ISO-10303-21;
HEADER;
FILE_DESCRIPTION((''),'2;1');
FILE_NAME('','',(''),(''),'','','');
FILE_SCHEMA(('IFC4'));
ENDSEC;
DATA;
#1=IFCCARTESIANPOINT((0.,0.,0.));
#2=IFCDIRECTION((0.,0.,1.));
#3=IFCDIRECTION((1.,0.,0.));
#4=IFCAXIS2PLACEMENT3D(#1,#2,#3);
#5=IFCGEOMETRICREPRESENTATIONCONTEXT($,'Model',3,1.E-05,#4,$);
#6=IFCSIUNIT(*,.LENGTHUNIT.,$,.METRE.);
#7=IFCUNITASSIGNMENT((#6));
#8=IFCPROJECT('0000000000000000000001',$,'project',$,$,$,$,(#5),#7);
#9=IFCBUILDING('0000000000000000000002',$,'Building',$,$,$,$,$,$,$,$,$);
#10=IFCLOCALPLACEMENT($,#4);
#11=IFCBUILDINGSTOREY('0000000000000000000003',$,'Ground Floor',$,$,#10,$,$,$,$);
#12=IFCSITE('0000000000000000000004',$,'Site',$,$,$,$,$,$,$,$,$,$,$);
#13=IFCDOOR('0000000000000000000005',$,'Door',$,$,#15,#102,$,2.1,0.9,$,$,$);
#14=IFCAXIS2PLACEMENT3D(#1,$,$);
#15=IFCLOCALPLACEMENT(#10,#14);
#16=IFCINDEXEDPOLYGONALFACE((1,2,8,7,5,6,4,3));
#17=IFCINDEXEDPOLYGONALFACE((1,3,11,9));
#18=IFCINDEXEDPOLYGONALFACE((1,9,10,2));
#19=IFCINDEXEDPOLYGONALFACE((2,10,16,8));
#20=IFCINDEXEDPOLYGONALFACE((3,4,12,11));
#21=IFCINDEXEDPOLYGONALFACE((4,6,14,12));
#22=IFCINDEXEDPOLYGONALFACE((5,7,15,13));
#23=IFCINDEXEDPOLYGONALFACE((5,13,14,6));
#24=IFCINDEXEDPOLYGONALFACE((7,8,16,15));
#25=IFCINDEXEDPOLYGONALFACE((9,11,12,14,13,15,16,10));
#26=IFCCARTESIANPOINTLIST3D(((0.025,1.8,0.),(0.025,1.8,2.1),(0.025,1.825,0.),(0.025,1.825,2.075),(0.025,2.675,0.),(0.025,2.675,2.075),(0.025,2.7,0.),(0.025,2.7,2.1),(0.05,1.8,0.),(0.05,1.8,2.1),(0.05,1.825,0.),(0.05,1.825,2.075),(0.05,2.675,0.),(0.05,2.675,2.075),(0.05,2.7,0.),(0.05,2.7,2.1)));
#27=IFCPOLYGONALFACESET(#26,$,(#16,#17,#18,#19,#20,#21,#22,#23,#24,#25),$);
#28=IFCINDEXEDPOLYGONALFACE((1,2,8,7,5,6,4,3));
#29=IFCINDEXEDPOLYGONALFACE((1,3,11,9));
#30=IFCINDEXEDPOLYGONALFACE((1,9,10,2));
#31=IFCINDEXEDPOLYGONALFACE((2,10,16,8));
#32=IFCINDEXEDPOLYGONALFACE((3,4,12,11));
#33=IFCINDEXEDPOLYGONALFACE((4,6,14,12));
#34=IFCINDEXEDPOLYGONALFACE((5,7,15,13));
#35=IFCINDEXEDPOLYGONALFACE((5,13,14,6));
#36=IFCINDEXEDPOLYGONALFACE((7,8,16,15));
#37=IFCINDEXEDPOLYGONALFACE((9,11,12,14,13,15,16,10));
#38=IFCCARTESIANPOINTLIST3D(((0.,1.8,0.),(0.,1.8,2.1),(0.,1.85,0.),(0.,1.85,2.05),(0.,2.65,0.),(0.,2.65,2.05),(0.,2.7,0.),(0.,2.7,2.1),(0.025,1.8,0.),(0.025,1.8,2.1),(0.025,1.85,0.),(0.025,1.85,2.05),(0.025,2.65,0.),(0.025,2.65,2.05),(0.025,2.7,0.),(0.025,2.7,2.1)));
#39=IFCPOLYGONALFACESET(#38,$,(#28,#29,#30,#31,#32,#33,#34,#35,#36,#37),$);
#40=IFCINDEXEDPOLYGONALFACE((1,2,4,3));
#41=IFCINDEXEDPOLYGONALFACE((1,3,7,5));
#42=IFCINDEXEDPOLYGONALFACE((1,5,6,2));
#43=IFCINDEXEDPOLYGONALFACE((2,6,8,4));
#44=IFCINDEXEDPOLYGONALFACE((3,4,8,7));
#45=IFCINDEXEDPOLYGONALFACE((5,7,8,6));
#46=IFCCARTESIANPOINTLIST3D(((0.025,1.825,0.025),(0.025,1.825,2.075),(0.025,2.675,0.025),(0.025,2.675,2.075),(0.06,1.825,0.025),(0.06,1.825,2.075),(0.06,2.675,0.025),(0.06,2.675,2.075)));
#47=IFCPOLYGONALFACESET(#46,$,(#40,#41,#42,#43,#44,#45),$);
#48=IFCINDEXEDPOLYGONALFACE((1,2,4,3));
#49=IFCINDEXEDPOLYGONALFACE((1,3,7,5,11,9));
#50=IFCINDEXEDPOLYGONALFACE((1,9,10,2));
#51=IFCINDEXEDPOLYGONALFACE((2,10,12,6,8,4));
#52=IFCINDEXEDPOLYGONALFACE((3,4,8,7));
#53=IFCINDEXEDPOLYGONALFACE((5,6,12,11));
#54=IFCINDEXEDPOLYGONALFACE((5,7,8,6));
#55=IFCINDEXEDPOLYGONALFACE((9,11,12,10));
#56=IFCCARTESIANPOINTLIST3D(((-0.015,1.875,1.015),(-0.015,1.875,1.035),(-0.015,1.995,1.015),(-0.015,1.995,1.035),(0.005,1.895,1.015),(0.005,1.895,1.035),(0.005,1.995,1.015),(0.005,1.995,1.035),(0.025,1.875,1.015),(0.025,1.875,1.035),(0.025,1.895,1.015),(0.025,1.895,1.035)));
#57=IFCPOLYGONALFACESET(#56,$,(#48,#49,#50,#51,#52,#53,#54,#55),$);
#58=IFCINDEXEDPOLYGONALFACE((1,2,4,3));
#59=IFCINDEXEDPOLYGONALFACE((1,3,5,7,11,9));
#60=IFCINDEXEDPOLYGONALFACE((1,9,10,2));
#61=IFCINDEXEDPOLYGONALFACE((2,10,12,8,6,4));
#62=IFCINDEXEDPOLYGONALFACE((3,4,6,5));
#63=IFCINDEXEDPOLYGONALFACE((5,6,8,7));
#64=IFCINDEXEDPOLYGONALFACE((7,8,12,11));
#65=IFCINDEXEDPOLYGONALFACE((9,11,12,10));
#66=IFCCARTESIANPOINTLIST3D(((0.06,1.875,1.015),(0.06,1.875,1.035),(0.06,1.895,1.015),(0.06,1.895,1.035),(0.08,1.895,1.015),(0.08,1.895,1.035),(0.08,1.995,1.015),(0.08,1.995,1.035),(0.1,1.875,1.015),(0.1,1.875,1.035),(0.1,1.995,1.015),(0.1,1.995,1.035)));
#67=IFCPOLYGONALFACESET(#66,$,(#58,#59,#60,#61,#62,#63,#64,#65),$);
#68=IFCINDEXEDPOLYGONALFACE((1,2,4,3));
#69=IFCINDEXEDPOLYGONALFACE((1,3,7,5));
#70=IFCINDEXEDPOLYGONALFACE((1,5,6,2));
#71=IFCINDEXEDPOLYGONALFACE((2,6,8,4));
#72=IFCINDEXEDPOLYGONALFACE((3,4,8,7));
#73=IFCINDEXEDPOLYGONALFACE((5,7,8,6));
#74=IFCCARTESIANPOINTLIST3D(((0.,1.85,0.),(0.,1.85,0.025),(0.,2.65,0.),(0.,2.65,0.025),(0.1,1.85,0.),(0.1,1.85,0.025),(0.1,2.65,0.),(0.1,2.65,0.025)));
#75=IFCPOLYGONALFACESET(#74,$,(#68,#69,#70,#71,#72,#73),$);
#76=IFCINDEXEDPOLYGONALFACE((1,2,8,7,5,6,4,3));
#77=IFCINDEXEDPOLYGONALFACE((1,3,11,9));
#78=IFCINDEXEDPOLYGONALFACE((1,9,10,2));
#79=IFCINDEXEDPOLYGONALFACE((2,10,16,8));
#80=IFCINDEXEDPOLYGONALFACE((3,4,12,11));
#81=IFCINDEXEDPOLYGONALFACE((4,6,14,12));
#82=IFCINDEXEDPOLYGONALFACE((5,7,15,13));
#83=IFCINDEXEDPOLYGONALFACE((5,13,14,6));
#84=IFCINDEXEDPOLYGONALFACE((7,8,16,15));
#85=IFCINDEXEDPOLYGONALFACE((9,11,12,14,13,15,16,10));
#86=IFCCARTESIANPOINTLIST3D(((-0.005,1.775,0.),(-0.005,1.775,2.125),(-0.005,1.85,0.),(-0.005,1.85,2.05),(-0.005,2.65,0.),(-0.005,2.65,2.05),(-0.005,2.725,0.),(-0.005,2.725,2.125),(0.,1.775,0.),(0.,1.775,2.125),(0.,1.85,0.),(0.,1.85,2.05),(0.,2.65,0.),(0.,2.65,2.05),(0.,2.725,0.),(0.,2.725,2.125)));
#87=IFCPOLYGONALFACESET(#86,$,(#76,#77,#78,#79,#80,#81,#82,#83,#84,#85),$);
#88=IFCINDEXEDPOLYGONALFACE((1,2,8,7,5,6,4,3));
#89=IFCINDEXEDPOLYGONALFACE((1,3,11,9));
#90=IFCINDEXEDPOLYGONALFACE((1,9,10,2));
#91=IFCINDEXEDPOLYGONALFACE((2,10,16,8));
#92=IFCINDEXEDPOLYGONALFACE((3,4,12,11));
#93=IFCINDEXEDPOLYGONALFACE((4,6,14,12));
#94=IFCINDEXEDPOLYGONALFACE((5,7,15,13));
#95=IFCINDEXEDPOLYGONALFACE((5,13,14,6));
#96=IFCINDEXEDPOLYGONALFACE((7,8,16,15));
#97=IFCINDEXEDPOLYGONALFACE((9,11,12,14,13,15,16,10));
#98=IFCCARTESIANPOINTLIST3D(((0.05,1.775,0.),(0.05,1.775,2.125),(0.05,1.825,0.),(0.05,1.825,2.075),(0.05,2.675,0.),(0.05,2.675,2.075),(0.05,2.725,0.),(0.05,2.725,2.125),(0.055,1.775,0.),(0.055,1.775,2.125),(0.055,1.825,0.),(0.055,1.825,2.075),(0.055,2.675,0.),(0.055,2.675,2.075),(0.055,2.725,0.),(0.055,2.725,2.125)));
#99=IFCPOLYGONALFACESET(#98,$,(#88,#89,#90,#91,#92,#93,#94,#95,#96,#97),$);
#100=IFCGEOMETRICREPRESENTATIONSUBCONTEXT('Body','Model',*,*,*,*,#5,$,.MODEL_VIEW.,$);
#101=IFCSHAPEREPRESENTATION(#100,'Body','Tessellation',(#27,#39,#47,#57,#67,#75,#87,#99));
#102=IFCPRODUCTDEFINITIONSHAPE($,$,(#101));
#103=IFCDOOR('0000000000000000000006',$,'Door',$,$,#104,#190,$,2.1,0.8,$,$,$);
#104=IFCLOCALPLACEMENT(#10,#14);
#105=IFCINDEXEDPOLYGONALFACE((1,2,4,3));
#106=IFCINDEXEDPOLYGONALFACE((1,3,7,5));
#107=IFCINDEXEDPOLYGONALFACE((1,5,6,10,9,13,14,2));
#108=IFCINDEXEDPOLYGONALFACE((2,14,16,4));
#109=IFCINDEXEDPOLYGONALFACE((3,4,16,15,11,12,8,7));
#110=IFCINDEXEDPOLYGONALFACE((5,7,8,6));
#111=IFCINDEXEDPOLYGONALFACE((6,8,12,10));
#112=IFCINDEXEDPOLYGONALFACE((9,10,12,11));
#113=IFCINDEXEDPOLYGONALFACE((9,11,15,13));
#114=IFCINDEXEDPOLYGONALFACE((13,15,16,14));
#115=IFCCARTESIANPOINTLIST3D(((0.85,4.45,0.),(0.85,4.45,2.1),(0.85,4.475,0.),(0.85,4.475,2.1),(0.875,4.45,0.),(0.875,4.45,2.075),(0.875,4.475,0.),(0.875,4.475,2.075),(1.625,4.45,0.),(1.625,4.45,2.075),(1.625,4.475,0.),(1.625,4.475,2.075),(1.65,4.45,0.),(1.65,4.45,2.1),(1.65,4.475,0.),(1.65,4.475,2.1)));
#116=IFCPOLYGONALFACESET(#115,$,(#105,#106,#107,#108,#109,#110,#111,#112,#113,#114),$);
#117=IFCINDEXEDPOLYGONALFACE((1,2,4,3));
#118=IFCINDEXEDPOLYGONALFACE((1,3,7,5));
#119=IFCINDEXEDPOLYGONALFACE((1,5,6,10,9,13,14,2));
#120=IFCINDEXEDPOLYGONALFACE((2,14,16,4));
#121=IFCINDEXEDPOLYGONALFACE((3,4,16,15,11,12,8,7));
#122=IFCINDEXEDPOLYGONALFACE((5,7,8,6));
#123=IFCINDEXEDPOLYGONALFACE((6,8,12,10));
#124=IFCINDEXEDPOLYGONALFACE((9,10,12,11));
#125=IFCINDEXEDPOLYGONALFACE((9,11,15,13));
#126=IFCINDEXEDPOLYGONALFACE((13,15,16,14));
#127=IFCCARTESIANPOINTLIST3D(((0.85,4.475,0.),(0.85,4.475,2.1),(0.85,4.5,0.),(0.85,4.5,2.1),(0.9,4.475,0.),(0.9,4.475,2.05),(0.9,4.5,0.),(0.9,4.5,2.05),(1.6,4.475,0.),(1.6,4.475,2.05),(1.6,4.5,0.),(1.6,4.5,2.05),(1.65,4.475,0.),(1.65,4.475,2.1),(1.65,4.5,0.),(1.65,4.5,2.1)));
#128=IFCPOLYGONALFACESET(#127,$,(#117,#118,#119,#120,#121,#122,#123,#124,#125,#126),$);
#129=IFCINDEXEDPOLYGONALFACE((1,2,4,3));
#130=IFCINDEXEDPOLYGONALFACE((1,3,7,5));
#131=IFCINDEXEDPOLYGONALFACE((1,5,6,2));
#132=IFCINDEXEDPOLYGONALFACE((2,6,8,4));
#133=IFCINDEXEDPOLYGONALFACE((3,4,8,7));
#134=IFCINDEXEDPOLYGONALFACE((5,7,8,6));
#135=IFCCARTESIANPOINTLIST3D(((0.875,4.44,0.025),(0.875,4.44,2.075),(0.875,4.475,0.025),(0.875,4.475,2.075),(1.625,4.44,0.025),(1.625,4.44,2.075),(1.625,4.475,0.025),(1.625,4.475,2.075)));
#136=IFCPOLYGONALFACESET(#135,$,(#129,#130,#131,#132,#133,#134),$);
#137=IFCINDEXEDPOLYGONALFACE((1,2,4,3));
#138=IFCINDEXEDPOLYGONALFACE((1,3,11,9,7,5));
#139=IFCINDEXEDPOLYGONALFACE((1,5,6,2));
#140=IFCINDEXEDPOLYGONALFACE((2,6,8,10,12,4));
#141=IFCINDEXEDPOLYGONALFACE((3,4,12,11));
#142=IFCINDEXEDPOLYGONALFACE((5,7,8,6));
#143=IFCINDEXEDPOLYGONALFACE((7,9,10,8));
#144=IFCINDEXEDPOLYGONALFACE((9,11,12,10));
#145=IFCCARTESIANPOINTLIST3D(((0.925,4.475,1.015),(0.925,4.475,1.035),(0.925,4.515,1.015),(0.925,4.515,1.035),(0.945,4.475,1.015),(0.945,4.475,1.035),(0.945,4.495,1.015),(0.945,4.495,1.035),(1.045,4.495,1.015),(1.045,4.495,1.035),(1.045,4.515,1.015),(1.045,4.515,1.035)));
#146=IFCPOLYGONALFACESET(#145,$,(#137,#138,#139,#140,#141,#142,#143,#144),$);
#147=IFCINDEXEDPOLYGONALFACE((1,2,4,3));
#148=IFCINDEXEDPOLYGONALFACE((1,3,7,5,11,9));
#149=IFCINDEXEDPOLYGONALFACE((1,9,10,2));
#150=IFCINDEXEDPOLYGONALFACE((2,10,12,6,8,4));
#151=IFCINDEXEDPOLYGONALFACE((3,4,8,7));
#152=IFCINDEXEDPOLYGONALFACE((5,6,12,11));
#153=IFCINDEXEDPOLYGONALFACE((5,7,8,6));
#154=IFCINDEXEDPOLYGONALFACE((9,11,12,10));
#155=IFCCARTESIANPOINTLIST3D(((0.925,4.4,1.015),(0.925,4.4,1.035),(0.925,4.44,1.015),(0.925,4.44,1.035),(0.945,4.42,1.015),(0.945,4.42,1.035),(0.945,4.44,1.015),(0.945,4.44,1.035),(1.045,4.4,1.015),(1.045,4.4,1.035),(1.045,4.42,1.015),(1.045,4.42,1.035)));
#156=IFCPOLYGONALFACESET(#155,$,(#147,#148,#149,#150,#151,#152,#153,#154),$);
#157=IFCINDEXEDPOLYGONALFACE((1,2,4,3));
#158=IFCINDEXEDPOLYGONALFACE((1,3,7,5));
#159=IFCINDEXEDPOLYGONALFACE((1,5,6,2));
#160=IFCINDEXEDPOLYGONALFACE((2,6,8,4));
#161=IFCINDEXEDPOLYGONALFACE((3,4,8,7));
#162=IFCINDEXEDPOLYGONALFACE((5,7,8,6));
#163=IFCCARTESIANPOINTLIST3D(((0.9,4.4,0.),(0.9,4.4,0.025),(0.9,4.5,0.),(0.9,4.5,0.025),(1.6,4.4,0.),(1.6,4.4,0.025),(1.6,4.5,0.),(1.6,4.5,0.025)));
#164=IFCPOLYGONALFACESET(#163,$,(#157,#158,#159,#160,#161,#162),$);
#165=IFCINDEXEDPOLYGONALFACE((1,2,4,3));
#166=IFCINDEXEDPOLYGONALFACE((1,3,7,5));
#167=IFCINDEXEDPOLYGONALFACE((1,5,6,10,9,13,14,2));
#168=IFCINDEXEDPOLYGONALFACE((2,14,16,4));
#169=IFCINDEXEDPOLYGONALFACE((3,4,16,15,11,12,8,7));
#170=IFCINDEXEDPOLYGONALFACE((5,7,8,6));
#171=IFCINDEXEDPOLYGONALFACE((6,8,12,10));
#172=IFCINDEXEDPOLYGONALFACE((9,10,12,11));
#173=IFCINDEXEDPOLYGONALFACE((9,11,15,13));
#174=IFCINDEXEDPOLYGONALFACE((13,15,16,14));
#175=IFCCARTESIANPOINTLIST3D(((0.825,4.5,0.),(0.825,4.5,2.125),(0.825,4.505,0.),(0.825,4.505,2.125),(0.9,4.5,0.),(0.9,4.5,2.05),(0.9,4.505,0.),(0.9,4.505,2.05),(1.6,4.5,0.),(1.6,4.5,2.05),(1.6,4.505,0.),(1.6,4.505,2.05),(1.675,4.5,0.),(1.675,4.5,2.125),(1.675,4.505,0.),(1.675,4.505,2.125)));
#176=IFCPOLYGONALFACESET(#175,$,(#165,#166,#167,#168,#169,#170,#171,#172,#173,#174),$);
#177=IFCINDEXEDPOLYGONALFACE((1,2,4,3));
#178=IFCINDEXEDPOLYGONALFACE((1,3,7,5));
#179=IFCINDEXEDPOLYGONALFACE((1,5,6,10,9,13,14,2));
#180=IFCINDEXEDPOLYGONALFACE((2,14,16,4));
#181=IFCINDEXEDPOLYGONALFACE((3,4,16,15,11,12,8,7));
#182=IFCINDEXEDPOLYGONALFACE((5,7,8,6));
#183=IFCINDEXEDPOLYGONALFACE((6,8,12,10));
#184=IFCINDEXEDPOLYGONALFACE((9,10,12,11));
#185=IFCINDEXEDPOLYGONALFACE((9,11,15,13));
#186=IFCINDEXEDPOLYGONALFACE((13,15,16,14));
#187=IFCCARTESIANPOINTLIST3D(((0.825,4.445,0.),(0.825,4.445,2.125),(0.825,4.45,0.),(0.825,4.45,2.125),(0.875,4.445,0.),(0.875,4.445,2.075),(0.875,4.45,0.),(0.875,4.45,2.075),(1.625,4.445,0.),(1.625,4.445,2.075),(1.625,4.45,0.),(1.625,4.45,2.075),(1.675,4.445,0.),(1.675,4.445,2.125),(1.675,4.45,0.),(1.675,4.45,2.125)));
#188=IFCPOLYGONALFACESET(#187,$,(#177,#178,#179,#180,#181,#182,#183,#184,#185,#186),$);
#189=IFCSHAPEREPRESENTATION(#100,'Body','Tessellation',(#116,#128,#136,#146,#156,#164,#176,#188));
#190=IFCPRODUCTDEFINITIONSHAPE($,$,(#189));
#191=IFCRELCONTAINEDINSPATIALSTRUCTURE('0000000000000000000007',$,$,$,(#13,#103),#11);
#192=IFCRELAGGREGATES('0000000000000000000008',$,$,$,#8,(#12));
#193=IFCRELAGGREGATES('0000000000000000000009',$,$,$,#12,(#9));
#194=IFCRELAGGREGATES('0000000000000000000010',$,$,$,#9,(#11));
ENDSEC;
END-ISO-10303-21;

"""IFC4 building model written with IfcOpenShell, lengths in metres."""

from ifc_helpers import new_model, si_unit, frame, origin_with_axes, place, context, subcontext, project, spatial, line, indexed_curve, outline, extrude, element, save


model = new_model("IFC4")

# Units and contexts
model_context = context("Model", 3, precision=1e-05, world=origin_with_axes())
body_context = subcontext(model_context, "Body", "Model", "MODEL_VIEW")
ifc_project = project(units=[si_unit("LENGTHUNIT", "METRE")], contexts=[model_context])

# Site, building, storey
site = spatial("IfcSite", under=ifc_project, Name="Site")
building = spatial("IfcBuilding", under=site, Name="Building")
storey_placement = place(None, origin_with_axes())
storey = spatial("IfcBuildingStorey", under=building, at=storey_placement, Name="Ground Floor")

# Doors
door_1_placement = place(storey_placement, frame((0.0, 2.7, 0.0), z_axis=(0.0, 0.0, 1.0), x_axis=(0.0, -1.0, 0.0)))
element("IfcDoor", 1, at=door_1_placement, inside=storey, Name="Door", OverallHeight=2.1, OverallWidth=0.9, context=body_context, shape_type="SweptSolid", body=[
    extrude(outline(indexed_curve([(0.0, 0.0), (0.0, 2.1), (0.9, 2.1), (0.9, 0.0), (0.875, 0.0), (0.875, 2.075), (0.025, 2.075), (0.025, 0.0)], segments=[line(1, 2, 3, 4, 5, 6, 7, 8, 1)])), frame((0.0, 0.025, 0.0), z_axis=(0.0, -1.0, 0.0), x_axis=(1.0, 0.0, 0.0)), (0.0, 0.0, -1.0), 0.025),
    extrude(outline(indexed_curve([(0.0, 0.0), (0.0, 2.1), (0.9, 2.1), (0.9, 0.0), (0.85, 0.0), (0.85, 2.05), (0.05, 2.05), (0.05, 0.0)], segments=[line(1, 2, 3, 4, 5, 6, 7, 8, 1)])), frame((0.0, 0.0, 0.0), z_axis=(0.0, -1.0, 0.0), x_axis=(1.0, 0.0, 0.0)), (0.0, 0.0, -1.0), 0.025),
    extrude(outline(indexed_curve([(0.0, 0.0), (0.85, 0.0), (0.85, 0.035), (0.0, 0.035)], segments=[line(1, 2, 3, 4, 1)])), frame((0.025, 0.025, 0.025), z_axis=(0.0, 0.0, 1.0), x_axis=(1.0, 0.0, 0.0)), (0.0, 0.0, 1.0), 2.05),
    extrude(outline(indexed_curve([(0.0, 0.0), (0.0, -0.04), (-0.12, -0.04), (-0.12, -0.02), (-0.02, -0.02), (-0.02, 0.0)], segments=[line(1, 2, 3, 4, 5, 6, 1)])), frame((0.825, 0.025, 1.015), z_axis=(0.0, 0.0, 1.0), x_axis=(1.0, 0.0, 0.0)), (0.0, 0.0, 1.0), 0.02),
    extrude(outline(indexed_curve([(0.0, 0.0), (0.0, 0.04), (-0.12, 0.04), (-0.12, 0.02), (-0.02, 0.02), (-0.02, 0.0)], segments=[line(1, 2, 3, 4, 5, 6, 1)])), frame((0.825, 0.06, 1.015), z_axis=(0.0, 0.0, 1.0), x_axis=(1.0, 0.0, 0.0)), (0.0, 0.0, 1.0), 0.02),
    extrude(outline(indexed_curve([(0.0, 0.0), (0.8, 0.0), (0.8, 0.1), (0.0, 0.1)], segments=[line(1, 2, 3, 4, 1)])), frame((0.05, 0.0, 0.0), z_axis=(0.0, 0.0, 1.0), x_axis=(1.0, 0.0, 0.0)), (0.0, 0.0, 1.0), 0.025),
    extrude(outline(indexed_curve([(0.0, 0.0), (0.0, 2.125), (0.95, 2.125), (0.95, 0.0), (0.875, 0.0), (0.875, 2.05), (0.075, 2.05), (0.075, 0.0)], segments=[line(1, 2, 3, 4, 5, 6, 7, 8, 1)])), frame((-0.025, -0.005, 0.0), z_axis=(0.0, -1.0, 0.0), x_axis=(1.0, 0.0, 0.0)), (0.0, 0.0, -1.0), 0.005),
    extrude(outline(indexed_curve([(0.0, 0.0), (0.0, 2.125), (0.95, 2.125), (0.95, 0.0), (0.9, 0.0), (0.9, 2.075), (0.05, 2.075), (0.05, 0.0)], segments=[line(1, 2, 3, 4, 5, 6, 7, 8, 1)])), frame((-0.025, 0.05, 0.0), z_axis=(0.0, -1.0, 0.0), x_axis=(1.0, 0.0, 0.0)), (0.0, 0.0, -1.0), 0.005),
])
door_2_placement = place(storey_placement, frame((1.65, 4.5, 0.0), z_axis=(0.0, 0.0, 1.0), x_axis=(-1.0, 0.0, 0.0)))
element("IfcDoor", 2, at=door_2_placement, inside=storey, Name="Door", OverallHeight=2.1, OverallWidth=0.8, context=body_context, shape_type="SweptSolid", body=[
    extrude(outline(indexed_curve([(0.0, 0.0), (0.0, 2.1), (0.8, 2.1), (0.8, 0.0), (0.775, 0.0), (0.775, 2.075), (0.025, 2.075), (0.025, 0.0)], segments=[line(1, 2, 3, 4, 5, 6, 7, 8, 1)])), frame((0.0, 0.025, 0.0), z_axis=(0.0, -1.0, 0.0), x_axis=(1.0, 0.0, 0.0)), (0.0, 0.0, -1.0), 0.025),
    extrude(outline(indexed_curve([(0.0, 0.0), (0.0, 2.1), (0.8, 2.1), (0.8, 0.0), (0.75, 0.0), (0.75, 2.05), (0.05, 2.05), (0.05, 0.0)], segments=[line(1, 2, 3, 4, 5, 6, 7, 8, 1)])), frame((0.0, 0.0, 0.0), z_axis=(0.0, -1.0, 0.0), x_axis=(1.0, 0.0, 0.0)), (0.0, 0.0, -1.0), 0.025),
    extrude(outline(indexed_curve([(0.0, 0.0), (0.75, 0.0), (0.75, 0.035), (0.0, 0.035)], segments=[line(1, 2, 3, 4, 1)])), frame((0.025, 0.025, 0.025), z_axis=(0.0, 0.0, 1.0), x_axis=(1.0, 0.0, 0.0)), (0.0, 0.0, 1.0), 2.05),
    extrude(outline(indexed_curve([(0.0, 0.0), (0.0, -0.04), (-0.12, -0.04), (-0.12, -0.02), (-0.02, -0.02), (-0.02, 0.0)], segments=[line(1, 2, 3, 4, 5, 6, 1)])), frame((0.725, 0.025, 1.015), z_axis=(0.0, 0.0, 1.0), x_axis=(1.0, 0.0, 0.0)), (0.0, 0.0, 1.0), 0.02),
    extrude(outline(indexed_curve([(0.0, 0.0), (0.0, 0.04), (-0.12, 0.04), (-0.12, 0.02), (-0.02, 0.02), (-0.02, 0.0)], segments=[line(1, 2, 3, 4, 5, 6, 1)])), frame((0.725, 0.06, 1.015), z_axis=(0.0, 0.0, 1.0), x_axis=(1.0, 0.0, 0.0)), (0.0, 0.0, 1.0), 0.02),
    extrude(outline(indexed_curve([(0.0, 0.0), (0.7, 0.0), (0.7, 0.1), (0.0, 0.1)], segments=[line(1, 2, 3, 4, 1)])), frame((0.05, 0.0, 0.0), z_axis=(0.0, 0.0, 1.0), x_axis=(1.0, 0.0, 0.0)), (0.0, 0.0, 1.0), 0.025),
    extrude(outline(indexed_curve([(0.0, 0.0), (0.0, 2.125), (0.85, 2.125), (0.85, 0.0), (0.775, 0.0), (0.775, 2.05), (0.075, 2.05), (0.075, 0.0)], segments=[line(1, 2, 3, 4, 5, 6, 7, 8, 1)])), frame((-0.025, -0.005, 0.0), z_axis=(0.0, -1.0, 0.0), x_axis=(1.0, 0.0, 0.0)), (0.0, 0.0, -1.0), 0.005),
    extrude(outline(indexed_curve([(0.0, 0.0), (0.0, 2.125), (0.85, 2.125), (0.85, 0.0), (0.8, 0.0), (0.8, 2.075), (0.05, 2.075), (0.05, 0.0)], segments=[line(1, 2, 3, 4, 5, 6, 7, 8, 1)])), frame((-0.025, 0.05, 0.0), z_axis=(0.0, -1.0, 0.0), x_axis=(1.0, 0.0, 0.0)), (0.0, 0.0, -1.0), 0.005),
])

save(model, "model.ifc")
